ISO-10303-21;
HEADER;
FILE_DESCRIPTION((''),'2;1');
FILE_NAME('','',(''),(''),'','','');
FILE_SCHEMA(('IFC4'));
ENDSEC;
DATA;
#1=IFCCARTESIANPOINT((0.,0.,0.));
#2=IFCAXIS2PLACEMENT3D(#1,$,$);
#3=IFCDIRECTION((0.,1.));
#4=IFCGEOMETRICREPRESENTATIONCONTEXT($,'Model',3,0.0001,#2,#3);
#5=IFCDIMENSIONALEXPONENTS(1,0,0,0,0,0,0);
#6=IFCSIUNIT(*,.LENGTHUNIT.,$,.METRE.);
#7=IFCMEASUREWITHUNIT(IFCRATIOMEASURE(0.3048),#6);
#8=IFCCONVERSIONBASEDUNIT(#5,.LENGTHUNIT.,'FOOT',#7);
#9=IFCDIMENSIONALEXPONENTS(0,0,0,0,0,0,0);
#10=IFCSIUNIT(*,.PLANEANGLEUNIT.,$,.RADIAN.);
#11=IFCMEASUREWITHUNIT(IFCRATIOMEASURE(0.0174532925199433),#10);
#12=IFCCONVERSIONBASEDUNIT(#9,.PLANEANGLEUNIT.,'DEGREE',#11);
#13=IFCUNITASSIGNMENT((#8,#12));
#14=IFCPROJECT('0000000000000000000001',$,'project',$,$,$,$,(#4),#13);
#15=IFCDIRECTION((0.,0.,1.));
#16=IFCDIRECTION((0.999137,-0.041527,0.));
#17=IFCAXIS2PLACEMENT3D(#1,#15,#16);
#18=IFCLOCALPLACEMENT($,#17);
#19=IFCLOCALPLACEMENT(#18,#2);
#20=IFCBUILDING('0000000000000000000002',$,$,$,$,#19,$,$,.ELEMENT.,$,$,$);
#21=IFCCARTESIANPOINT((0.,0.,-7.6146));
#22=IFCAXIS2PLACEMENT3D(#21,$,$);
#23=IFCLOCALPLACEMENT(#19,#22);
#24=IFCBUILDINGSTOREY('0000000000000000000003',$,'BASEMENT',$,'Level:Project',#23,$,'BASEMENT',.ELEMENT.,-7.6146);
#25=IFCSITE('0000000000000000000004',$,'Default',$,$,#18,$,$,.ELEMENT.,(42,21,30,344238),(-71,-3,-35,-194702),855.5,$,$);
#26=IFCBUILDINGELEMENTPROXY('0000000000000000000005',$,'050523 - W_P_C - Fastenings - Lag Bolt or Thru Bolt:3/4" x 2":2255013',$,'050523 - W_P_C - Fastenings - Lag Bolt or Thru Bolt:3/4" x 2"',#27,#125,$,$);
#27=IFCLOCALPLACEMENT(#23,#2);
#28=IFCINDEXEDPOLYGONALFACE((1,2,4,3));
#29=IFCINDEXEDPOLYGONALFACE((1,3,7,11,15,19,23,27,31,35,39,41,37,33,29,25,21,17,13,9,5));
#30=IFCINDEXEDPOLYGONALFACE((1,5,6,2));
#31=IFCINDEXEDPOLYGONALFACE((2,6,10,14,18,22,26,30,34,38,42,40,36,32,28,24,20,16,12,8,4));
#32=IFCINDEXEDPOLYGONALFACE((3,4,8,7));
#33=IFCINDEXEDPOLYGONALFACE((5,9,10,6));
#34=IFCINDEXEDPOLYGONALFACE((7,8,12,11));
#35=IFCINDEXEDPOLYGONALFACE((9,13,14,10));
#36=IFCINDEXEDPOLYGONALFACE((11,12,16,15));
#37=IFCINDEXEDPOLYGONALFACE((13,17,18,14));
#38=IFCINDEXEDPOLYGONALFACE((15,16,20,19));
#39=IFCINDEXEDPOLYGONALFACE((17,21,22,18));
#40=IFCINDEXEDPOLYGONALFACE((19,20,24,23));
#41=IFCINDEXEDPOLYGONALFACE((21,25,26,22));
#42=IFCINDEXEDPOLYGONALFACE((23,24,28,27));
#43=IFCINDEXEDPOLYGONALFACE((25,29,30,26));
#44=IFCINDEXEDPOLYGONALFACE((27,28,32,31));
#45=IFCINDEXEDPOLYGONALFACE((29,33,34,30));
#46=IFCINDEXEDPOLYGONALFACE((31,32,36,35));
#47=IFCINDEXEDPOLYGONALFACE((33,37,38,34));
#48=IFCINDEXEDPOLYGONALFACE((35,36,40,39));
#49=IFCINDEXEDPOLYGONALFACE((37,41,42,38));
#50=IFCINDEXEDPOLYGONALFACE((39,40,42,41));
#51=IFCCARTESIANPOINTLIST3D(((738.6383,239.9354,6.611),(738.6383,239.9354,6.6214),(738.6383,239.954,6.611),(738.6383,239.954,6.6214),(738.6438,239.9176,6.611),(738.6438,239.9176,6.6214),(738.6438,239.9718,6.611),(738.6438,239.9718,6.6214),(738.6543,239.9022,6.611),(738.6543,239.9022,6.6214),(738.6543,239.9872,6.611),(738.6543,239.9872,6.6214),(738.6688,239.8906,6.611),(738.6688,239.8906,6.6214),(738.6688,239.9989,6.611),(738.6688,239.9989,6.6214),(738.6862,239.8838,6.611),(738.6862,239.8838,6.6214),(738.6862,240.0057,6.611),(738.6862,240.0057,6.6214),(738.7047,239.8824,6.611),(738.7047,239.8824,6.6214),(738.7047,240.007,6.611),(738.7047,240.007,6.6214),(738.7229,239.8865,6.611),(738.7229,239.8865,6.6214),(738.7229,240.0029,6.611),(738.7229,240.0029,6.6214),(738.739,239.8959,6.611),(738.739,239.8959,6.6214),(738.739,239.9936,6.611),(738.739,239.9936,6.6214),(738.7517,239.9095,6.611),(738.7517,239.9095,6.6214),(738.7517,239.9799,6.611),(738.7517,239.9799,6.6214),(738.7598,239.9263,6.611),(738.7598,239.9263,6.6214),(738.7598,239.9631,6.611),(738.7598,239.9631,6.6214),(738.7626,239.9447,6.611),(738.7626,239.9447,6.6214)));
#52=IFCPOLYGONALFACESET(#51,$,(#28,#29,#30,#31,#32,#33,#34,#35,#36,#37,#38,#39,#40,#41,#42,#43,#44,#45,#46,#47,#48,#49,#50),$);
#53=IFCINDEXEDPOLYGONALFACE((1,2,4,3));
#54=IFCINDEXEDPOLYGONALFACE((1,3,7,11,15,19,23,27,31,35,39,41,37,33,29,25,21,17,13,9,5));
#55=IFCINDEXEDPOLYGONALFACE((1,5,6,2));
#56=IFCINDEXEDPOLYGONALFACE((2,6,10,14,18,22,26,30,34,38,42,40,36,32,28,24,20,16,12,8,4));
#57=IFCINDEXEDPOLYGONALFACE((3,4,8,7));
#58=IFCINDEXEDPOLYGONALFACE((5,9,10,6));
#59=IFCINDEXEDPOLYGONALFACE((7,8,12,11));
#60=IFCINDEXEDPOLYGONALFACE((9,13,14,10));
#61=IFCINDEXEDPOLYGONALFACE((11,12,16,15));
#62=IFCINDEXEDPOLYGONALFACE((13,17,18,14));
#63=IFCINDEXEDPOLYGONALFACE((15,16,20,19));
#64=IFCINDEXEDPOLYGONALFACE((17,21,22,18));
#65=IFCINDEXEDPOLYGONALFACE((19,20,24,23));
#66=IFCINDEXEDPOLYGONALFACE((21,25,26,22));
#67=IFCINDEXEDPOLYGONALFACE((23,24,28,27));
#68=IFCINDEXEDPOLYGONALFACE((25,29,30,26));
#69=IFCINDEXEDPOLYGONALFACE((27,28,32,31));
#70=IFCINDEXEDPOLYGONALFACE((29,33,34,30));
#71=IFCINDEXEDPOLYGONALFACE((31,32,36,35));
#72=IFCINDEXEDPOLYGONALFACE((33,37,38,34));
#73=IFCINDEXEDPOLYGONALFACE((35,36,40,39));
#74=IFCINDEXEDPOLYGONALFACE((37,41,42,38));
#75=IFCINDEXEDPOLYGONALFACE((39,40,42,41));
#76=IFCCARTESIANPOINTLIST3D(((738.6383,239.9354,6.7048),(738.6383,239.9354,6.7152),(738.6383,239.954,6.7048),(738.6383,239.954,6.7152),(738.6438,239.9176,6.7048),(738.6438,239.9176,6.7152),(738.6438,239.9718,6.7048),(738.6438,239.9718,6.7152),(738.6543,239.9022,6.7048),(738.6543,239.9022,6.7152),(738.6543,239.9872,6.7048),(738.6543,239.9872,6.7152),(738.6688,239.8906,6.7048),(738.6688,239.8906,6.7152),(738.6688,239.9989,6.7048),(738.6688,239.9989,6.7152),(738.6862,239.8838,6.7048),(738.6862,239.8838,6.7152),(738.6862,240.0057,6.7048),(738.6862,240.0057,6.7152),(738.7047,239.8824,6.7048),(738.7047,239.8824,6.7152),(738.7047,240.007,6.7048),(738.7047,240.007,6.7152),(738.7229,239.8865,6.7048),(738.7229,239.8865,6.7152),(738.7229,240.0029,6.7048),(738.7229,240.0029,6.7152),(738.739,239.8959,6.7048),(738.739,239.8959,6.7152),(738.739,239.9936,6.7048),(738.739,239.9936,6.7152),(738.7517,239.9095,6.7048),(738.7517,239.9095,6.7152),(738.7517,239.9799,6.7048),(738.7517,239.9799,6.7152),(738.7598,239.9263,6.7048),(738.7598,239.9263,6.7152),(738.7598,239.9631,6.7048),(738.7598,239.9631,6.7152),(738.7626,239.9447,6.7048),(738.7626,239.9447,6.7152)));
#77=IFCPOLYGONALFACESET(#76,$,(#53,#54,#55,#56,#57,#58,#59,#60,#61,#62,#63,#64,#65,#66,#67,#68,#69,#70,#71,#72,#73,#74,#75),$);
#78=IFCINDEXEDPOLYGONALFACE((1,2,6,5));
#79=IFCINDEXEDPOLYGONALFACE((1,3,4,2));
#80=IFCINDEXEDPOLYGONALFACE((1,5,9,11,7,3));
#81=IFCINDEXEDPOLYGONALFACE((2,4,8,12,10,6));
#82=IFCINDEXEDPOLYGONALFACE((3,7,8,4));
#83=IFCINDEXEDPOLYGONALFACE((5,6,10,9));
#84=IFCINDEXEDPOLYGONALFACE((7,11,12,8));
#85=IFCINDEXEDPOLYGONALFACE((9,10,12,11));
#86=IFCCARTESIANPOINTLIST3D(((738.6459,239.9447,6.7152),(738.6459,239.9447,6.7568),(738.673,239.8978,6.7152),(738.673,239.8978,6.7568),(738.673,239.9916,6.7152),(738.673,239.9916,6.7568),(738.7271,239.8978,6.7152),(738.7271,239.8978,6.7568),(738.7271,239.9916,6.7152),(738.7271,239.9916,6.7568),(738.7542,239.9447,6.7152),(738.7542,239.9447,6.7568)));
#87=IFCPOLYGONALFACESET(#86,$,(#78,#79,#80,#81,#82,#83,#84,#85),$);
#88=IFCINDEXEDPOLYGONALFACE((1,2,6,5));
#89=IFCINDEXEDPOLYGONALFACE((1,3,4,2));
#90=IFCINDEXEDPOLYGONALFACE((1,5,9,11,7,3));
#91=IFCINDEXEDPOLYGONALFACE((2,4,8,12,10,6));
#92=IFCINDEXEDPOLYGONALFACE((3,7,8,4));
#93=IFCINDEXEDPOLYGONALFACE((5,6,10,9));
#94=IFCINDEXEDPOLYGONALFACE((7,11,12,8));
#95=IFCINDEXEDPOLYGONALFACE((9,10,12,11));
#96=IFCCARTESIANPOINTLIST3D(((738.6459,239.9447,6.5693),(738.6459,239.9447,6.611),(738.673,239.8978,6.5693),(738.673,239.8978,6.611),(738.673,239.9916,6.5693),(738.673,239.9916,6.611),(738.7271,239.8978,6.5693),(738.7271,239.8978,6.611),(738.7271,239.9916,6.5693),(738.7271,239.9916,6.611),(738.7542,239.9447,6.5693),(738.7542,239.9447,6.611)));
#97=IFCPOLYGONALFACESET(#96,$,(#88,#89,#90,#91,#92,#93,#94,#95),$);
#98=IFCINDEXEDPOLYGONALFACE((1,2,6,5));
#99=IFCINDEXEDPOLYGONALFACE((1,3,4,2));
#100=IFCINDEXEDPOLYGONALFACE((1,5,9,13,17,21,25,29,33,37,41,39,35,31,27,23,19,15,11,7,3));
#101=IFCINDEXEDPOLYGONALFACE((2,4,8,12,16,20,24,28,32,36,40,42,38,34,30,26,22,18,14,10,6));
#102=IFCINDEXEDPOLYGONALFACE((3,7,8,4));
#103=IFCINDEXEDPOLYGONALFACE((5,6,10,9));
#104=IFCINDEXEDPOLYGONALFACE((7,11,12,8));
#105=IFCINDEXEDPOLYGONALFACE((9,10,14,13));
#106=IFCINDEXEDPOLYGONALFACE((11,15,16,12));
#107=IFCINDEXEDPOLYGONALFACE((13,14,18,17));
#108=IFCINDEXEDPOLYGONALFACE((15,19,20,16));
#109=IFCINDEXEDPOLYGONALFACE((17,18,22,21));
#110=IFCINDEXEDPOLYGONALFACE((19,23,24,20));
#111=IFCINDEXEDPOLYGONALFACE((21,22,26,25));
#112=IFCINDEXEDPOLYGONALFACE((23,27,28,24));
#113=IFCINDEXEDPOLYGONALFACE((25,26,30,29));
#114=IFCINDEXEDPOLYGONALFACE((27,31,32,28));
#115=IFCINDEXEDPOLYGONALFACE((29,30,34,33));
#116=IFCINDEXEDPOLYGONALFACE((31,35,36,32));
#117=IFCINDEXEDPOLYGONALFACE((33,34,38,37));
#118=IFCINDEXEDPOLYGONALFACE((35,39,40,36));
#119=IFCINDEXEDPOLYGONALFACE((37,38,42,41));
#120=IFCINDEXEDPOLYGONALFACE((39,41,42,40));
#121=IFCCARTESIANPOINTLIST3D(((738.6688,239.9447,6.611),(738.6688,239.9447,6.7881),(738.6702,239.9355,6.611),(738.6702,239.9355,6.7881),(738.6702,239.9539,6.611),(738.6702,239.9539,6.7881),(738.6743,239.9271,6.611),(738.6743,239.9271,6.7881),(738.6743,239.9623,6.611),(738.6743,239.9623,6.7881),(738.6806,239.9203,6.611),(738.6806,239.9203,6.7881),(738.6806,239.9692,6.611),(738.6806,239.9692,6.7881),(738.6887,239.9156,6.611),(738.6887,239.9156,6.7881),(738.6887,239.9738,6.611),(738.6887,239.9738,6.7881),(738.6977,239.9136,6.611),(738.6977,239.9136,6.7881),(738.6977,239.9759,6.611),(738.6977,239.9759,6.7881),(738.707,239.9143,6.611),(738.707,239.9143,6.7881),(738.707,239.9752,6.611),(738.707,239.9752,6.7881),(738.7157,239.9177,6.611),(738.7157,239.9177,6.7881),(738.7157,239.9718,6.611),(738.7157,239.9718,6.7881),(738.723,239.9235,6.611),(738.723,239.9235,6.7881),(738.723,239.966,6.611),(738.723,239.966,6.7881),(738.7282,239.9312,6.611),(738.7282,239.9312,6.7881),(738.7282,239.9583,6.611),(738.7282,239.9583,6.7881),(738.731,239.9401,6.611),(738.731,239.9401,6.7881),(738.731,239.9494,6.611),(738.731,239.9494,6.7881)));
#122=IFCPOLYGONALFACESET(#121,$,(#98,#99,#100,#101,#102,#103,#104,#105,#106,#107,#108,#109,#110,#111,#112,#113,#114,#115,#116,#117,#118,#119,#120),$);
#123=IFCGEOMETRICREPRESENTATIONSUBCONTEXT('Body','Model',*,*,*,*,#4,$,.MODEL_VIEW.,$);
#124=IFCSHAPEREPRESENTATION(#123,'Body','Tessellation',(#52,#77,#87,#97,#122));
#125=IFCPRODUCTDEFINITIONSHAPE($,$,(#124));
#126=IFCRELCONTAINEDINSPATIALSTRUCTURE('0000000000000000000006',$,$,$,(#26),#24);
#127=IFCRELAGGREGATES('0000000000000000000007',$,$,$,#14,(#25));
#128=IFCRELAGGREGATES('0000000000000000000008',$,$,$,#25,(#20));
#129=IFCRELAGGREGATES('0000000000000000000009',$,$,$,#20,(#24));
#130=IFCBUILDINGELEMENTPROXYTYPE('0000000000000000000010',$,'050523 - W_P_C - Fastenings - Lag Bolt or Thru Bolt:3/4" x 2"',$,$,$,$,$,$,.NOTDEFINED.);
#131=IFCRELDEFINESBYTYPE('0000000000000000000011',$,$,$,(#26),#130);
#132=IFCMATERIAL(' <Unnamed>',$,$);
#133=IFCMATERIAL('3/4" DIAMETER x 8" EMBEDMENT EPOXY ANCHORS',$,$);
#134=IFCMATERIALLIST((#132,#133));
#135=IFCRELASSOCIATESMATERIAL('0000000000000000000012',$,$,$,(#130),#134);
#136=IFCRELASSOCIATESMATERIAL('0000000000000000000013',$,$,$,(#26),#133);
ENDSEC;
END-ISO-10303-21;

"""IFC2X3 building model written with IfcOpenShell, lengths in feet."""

from ifc_helpers import new_model, entity, si_unit, converted_unit, direction, frame, frame_2d, origin, place, context, subcontext, project, spatial, polyline, circle, outline, extrude, source, transform, mapped, material, material_list, type_object, type_shapes, element, save


model = new_model("IFC2X3")

# Units and contexts
model_context = context("Model", 3, precision=0.0001, world=origin(), true_north=direction((0.0, 1.0)))
body_context = subcontext(model_context, "Body", "Model", "MODEL_VIEW")
ifc_project = project(units=[converted_unit("LENGTHUNIT", "FOOT", entity("IfcRatioMeasure", 0.3048), si_unit("LENGTHUNIT", "METRE"), dimensions=[1, 0, 0, 0, 0, 0, 0]), converted_unit("PLANEANGLEUNIT", "DEGREE", entity("IfcRatioMeasure", 0.0174532925199433), si_unit("PLANEANGLEUNIT", "RADIAN"), dimensions=[0, 0, 0, 0, 0, 0, 0])], contexts=[model_context])

# Site, building, storey
site_placement = place(None, frame((0.0, 0.0, 0.0), z_axis=(0.0, 0.0, 1.0), x_axis=(0.999137, -0.041527, 0.0)))
site = spatial("IfcSite", under=ifc_project, at=site_placement, Name="Default", CompositionType="ELEMENT", RefLatitude=(42, 21, 30, 344238), RefLongitude=(-71, -3, -35, -194702), RefElevation=855.5)
building_placement = place(site_placement, origin())
building = spatial("IfcBuilding", under=site, at=building_placement, CompositionType="ELEMENT")
storey_placement = place(building_placement, frame((0.0, 0.0, -7.6146)))
storey = spatial("IfcBuildingStorey", under=building, at=storey_placement, Name="BASEMENT", ObjectType="Level:Project", LongName="BASEMENT", CompositionType="ELEMENT", Elevation=-7.6146)

# Building element proxy
ifc_material_1 = material(Name=" <Unnamed>")
ifc_material_2 = material(Name="3/4\" DIAMETER x 8\" EMBEDMENT EPOXY ANCHORS")
ifc_material_list_1 = material_list([ifc_material_1, ifc_material_2])
building_element_proxy_type_1 = type_object("IfcBuildingElementProxyType", Name="050523 - W_P_C - Fastenings - Lag Bolt or Thru Bolt:3/4\" x 2\"", PredefinedType="NOTDEFINED", material=ifc_material_list_1)
shared_shape_1 = source(origin(), body_context, "Body", "SweptSolid", [
    extrude(circle(Radius=0.0625, at=frame_2d((0.0, 0.0), x_axis=(1.0, 0.0))), frame((0.0, 0.0, 0.0), z_axis=(0.0, 0.0, 1.0), x_axis=(0.0, -1.0, 0.0)), (0.0, 0.0, 1.0), 0.0104),
    extrude(circle(Radius=0.0625, at=frame_2d((0.0, 0.0), x_axis=(1.0, 0.0))), frame((0.0, 0.0, -0.0938), z_axis=(0.0, 0.0, 1.0), x_axis=(0.0, -1.0, 0.0)), (0.0, 0.0, 1.0), 0.0104),
    extrude(outline(polyline([(-0.0271, -0.0469), (0.0271, -0.0469), (0.0541, 0.0), (0.0271, 0.0469), (-0.0271, 0.0469), (-0.0541, 0.0), (-0.0271, -0.0469)])), frame((0.0, 0.0, -0.1354), z_axis=(0.0, 0.0, 1.0), x_axis=(0.866025, -0.5, 0.0)), (0.0, 0.0, 1.0), 0.0417),
    extrude(outline(polyline([(-0.0271, -0.0469), (0.0271, -0.0469), (0.0541, 0.0), (0.0271, 0.0469), (-0.0271, 0.0469), (-0.0541, 0.0), (-0.0271, -0.0469)])), frame((0.0, 0.0, 0.0104), z_axis=(0.0, 0.0, 1.0), x_axis=(0.0, -1.0, 0.0)), (0.0, 0.0, 1.0), 0.0417),
    extrude(circle(Radius=0.0312, at=frame_2d((0.0, 0.0), x_axis=(1.0, 0.0))), frame((0.0, 0.0, -0.1667), z_axis=(0.0, 0.0, 1.0), x_axis=(0.0, 1.0, 0.0)), (0.0, 0.0, 1.0), 0.1771),
])
type_shapes(building_element_proxy_type_1, [shared_shape_1])
for number, where, z_axis, x_axis, name in (
    (1, (738.7001, 239.9447, 6.6214), (0.0, 0.0, -1.0), (0.0, -1.0, 0.0), "050523 - W_P_C - Fastenings - Lag Bolt or Thru Bolt:3/4\" x 2\":2255013"),
):
    element("IfcBuildingElementProxy", number, at=place(storey_placement, frame(where, z_axis=z_axis, x_axis=x_axis)), inside=storey, type_object=building_element_proxy_type_1, material=ifc_material_2, Name=name, ObjectType="050523 - W_P_C - Fastenings - Lag Bolt or Thru Bolt:3/4\" x 2\"", context=body_context, shape_type="MappedRepresentation", body=[
        mapped(shared_shape_1, transform((0.0, 0.0, 0.0), scale=1.0)),
    ])

save(model, "model.ifc")
